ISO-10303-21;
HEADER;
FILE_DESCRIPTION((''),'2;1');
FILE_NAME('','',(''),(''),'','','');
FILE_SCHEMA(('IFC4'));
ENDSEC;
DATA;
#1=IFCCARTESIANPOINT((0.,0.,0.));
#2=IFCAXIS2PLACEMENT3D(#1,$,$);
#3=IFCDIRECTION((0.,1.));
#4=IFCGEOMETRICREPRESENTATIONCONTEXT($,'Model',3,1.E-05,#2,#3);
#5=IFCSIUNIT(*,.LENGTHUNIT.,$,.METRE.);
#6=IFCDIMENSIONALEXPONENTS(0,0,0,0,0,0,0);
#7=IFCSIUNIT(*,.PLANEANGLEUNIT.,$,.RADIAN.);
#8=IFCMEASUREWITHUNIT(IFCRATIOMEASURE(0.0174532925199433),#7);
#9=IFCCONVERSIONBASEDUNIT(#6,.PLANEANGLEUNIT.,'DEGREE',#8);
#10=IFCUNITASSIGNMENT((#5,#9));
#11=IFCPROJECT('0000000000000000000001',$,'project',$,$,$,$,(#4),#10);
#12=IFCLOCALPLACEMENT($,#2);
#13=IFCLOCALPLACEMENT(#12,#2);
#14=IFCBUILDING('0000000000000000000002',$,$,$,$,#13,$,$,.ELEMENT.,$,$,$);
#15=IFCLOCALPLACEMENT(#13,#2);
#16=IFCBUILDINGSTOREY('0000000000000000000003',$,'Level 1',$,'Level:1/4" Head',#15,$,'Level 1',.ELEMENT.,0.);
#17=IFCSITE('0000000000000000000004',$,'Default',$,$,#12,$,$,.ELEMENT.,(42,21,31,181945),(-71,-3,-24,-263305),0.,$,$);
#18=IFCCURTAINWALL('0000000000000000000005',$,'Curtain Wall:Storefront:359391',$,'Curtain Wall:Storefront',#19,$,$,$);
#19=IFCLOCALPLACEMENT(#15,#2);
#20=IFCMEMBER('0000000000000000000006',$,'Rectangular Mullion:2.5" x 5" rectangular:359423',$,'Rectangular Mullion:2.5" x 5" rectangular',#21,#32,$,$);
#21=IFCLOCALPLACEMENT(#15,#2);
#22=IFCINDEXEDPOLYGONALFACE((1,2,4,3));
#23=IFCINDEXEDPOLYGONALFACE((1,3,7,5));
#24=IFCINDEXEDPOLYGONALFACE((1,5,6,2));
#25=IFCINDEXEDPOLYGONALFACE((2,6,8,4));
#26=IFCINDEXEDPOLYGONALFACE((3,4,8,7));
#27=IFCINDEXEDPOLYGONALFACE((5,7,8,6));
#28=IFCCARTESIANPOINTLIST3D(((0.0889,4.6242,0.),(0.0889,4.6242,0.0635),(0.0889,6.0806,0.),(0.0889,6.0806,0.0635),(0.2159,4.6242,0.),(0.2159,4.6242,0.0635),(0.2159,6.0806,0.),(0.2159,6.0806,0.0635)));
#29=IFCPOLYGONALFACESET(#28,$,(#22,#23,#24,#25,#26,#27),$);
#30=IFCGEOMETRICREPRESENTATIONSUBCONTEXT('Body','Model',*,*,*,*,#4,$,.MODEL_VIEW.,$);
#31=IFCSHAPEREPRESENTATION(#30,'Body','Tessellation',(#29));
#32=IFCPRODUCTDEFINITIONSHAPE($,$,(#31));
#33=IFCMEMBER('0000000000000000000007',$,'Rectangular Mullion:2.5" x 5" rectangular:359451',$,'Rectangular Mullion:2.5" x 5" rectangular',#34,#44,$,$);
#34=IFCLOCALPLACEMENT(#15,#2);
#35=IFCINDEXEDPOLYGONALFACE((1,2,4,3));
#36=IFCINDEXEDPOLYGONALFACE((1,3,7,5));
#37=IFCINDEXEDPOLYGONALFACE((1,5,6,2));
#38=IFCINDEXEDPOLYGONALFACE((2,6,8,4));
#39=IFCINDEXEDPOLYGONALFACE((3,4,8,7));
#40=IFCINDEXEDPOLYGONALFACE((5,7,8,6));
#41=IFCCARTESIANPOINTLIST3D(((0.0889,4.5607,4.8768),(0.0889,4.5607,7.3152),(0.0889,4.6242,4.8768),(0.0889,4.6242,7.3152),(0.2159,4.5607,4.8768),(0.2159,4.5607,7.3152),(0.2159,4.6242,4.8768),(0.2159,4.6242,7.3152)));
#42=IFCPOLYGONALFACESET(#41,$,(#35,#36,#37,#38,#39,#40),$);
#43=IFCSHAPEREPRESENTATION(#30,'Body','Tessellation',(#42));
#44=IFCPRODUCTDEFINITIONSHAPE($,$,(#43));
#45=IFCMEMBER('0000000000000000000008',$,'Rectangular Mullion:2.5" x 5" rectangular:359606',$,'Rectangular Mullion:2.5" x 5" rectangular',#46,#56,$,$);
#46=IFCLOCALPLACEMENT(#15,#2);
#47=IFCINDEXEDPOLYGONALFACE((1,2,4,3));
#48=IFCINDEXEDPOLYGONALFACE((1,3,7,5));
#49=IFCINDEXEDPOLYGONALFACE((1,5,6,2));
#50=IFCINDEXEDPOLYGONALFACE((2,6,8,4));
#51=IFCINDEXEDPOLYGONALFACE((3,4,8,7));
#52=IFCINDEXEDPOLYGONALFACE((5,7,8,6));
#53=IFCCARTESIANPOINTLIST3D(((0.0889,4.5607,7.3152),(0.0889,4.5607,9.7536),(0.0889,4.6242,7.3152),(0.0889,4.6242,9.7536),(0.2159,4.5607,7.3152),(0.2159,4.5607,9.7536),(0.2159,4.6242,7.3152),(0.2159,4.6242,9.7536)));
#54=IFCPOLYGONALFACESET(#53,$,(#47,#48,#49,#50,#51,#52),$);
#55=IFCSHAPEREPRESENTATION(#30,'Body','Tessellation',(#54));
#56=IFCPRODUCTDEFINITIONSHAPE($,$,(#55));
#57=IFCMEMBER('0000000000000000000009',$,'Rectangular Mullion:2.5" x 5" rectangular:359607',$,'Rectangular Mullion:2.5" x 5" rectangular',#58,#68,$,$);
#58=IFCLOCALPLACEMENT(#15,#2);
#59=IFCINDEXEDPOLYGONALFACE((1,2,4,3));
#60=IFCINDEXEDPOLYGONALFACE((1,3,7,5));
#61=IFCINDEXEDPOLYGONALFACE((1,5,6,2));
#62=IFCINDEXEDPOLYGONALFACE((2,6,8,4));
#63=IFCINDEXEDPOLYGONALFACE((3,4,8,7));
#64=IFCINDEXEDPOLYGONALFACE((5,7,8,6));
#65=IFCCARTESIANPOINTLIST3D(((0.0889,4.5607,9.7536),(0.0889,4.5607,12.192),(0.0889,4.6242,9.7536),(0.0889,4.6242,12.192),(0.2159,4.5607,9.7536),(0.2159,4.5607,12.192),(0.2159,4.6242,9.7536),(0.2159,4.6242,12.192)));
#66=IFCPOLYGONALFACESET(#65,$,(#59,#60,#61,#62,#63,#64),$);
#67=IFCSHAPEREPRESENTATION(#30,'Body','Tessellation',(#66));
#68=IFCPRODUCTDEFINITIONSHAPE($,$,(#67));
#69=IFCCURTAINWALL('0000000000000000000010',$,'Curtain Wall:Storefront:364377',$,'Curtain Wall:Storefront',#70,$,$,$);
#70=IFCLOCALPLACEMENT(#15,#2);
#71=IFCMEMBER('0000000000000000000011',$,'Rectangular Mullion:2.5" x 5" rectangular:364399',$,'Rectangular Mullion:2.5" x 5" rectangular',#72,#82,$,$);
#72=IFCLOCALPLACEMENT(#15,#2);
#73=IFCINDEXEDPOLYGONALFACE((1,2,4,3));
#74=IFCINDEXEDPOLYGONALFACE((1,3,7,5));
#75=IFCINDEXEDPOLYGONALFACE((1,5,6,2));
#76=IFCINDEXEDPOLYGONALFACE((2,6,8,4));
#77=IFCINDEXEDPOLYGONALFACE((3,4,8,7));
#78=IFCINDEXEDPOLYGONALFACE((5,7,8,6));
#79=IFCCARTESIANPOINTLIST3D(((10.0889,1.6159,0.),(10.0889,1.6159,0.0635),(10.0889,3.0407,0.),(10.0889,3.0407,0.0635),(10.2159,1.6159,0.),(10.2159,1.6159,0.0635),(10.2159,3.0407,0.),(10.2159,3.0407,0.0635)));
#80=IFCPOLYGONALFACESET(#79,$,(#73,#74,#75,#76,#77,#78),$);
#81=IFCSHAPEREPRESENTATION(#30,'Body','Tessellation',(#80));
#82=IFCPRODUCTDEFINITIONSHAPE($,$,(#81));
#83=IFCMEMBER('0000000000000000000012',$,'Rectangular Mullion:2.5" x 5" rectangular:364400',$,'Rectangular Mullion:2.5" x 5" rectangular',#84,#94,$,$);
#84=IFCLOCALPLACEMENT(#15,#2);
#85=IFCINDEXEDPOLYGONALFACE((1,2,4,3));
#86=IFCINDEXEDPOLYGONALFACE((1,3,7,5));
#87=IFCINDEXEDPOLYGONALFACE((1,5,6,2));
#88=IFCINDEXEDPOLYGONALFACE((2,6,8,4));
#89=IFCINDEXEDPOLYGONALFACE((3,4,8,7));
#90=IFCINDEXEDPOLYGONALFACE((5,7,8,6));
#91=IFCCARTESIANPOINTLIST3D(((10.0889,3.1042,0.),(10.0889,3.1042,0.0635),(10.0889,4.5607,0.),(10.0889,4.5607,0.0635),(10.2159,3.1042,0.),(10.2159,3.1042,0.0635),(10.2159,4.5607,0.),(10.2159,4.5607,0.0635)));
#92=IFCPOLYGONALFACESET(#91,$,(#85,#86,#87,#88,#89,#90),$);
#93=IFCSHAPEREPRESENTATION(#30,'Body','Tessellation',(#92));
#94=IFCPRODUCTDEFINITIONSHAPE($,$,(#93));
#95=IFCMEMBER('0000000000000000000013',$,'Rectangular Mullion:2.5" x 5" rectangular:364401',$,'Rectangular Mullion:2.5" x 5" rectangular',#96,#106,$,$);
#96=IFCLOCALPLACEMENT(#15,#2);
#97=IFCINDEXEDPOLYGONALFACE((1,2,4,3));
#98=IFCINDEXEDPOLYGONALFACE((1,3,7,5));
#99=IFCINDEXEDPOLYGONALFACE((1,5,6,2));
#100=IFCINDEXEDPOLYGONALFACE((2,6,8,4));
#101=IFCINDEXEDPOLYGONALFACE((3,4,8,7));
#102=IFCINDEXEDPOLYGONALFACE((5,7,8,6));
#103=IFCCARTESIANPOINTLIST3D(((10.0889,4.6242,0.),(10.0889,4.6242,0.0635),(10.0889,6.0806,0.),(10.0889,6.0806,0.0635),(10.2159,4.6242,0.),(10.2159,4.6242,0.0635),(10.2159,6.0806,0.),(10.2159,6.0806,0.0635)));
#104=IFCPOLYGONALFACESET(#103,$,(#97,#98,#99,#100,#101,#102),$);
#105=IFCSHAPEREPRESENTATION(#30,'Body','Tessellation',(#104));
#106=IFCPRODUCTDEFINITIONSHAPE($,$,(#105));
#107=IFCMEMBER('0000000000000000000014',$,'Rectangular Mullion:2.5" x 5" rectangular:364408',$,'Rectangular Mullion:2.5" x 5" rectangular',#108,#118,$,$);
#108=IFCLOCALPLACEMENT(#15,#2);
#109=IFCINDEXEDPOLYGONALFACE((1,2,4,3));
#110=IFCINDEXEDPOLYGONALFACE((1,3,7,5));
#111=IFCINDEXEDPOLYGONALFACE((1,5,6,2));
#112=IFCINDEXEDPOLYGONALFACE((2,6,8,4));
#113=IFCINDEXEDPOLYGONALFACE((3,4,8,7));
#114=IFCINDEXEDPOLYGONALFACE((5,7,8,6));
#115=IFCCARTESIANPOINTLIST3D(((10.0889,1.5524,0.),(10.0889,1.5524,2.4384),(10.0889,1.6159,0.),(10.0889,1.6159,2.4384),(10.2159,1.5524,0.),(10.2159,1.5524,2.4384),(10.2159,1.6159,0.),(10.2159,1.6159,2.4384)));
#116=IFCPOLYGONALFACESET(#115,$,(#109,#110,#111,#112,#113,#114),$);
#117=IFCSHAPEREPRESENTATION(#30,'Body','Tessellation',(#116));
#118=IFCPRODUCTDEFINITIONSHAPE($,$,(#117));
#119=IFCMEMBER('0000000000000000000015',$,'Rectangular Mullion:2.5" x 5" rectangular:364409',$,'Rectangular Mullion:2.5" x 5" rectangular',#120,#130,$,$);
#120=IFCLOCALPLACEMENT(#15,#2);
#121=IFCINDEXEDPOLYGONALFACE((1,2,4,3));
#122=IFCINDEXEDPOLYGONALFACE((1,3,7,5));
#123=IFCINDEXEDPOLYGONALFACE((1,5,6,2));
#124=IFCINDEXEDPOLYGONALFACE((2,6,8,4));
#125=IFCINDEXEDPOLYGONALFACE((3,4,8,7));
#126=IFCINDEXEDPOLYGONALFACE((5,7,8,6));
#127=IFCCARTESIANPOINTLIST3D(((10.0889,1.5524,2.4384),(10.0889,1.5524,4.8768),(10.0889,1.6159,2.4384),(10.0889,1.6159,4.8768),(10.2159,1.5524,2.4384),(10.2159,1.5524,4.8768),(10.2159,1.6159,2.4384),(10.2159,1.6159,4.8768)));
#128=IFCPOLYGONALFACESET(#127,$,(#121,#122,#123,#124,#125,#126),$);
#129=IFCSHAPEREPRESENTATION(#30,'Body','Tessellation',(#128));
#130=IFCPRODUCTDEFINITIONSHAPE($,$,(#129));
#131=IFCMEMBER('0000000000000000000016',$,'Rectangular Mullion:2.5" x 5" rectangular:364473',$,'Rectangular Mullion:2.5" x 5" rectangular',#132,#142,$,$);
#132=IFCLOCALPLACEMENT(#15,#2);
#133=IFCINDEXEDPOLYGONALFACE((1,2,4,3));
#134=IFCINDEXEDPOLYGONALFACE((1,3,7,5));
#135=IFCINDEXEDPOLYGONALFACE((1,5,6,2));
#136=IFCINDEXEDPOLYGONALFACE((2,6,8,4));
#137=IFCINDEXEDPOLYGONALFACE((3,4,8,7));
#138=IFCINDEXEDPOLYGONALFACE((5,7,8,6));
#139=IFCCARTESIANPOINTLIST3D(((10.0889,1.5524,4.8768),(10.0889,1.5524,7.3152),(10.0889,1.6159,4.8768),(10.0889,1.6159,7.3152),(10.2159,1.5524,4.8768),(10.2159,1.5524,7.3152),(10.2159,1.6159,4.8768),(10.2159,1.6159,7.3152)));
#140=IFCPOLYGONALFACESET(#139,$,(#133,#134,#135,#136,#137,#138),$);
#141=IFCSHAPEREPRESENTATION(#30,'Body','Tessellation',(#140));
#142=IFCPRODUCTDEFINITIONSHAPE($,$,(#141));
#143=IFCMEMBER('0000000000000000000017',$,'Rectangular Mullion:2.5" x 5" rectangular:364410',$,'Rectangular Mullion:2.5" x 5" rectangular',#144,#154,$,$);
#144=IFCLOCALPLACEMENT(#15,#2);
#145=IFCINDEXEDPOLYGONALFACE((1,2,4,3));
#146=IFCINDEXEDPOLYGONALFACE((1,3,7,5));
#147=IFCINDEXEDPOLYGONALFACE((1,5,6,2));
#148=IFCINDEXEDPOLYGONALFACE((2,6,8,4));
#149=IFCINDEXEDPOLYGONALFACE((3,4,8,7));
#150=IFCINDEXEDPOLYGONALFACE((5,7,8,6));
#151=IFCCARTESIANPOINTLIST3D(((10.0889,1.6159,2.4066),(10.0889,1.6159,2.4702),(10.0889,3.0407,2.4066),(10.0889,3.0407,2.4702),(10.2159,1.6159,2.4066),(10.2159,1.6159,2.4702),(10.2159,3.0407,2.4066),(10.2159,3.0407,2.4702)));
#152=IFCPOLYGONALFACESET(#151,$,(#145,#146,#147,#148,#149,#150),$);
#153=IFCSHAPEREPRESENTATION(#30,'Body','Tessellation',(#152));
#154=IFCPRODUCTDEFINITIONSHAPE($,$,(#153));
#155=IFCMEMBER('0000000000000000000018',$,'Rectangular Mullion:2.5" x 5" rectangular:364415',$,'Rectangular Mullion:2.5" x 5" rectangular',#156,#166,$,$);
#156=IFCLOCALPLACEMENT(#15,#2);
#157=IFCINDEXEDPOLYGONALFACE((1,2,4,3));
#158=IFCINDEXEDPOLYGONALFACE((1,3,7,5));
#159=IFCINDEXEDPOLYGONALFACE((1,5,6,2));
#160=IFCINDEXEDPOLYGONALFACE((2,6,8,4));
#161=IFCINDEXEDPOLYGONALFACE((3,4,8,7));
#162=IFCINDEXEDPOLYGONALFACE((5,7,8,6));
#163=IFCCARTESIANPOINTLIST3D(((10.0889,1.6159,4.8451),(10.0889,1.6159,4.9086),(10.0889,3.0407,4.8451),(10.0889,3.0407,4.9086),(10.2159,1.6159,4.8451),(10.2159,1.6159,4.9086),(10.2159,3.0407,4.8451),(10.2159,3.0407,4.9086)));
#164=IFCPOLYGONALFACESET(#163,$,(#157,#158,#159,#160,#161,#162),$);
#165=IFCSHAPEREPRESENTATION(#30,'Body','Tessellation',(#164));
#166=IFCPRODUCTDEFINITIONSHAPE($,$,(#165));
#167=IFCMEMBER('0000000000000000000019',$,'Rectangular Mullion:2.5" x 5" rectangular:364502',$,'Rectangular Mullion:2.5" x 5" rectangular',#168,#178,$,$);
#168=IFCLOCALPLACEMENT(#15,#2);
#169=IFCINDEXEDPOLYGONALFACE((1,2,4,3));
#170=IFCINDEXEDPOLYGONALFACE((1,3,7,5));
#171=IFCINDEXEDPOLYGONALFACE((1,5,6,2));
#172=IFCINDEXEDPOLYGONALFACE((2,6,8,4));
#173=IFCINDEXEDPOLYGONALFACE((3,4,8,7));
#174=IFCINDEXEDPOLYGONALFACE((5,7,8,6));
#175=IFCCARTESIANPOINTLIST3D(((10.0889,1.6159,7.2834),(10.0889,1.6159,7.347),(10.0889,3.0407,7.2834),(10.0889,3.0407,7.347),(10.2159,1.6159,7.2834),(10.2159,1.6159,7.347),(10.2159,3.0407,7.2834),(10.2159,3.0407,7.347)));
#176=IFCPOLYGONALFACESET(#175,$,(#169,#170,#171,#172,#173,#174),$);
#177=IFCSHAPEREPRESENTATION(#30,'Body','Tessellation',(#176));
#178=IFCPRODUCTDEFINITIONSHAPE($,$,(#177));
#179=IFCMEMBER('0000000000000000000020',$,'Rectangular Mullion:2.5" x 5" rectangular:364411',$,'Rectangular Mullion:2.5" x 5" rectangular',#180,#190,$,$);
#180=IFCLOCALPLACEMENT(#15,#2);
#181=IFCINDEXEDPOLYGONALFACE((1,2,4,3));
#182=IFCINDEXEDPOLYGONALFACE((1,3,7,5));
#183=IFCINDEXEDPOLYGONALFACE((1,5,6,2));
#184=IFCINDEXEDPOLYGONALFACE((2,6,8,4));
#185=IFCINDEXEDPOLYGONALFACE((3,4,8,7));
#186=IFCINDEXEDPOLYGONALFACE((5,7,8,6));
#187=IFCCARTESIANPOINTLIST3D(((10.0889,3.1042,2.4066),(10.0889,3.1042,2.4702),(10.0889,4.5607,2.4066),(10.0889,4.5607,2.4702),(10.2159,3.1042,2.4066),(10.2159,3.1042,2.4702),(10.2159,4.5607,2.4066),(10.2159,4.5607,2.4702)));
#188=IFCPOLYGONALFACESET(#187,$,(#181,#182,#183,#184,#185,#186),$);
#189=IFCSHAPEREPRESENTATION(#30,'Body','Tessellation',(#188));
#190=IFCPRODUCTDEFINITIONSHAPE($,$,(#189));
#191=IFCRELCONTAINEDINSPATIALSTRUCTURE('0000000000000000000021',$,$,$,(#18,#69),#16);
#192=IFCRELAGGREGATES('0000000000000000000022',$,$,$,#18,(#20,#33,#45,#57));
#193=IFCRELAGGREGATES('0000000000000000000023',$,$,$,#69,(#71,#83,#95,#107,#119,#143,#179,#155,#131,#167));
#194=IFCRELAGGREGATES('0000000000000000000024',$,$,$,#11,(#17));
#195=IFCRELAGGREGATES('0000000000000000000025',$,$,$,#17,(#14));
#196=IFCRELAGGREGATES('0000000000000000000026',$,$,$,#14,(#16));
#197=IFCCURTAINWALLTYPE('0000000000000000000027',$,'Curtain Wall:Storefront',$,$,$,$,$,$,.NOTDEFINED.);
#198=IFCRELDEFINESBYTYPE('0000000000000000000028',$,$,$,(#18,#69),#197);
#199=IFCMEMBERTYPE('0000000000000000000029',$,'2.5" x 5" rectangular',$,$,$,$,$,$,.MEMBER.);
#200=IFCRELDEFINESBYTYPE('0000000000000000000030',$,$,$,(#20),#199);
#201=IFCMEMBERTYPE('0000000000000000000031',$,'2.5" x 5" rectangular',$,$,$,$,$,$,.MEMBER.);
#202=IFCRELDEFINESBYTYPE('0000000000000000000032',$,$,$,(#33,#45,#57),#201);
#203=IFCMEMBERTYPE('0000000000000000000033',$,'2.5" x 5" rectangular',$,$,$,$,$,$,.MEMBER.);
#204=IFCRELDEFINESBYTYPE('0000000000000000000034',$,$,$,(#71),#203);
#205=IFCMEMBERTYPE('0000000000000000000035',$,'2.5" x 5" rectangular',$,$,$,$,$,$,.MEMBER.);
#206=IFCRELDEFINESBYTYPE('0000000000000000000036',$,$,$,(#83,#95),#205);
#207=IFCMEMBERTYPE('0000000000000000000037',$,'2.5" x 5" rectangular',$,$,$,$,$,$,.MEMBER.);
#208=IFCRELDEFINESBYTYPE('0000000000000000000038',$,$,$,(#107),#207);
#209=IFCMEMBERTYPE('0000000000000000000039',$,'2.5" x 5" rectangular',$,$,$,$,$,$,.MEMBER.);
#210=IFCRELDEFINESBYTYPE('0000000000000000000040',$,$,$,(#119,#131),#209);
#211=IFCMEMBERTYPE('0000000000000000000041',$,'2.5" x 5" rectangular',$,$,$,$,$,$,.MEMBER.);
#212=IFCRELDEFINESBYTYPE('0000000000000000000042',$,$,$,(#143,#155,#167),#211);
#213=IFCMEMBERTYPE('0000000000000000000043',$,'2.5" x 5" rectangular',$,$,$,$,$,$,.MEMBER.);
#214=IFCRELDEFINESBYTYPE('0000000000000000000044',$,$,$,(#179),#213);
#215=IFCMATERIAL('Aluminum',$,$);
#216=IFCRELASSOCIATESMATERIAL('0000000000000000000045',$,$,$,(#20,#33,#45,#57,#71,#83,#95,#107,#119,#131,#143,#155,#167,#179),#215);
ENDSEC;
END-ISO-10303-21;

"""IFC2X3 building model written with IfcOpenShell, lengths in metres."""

from ifc_helpers import new_model, entity, si_unit, converted_unit, direction, frame, origin, origin_2d_with_axis, place, context, subcontext, project, spatial, rectangle, extrude, source, transform, mapped, material, type_object, type_shapes, element, aggregate, save


model = new_model("IFC2X3")

# Units and contexts
model_context = context("Model", 3, precision=1e-05, world=origin(), true_north=direction((0.0, 1.0)))
body_context = subcontext(model_context, "Body", "Model", "MODEL_VIEW")
ifc_project = project(units=[si_unit("LENGTHUNIT", "METRE"), converted_unit("PLANEANGLEUNIT", "DEGREE", entity("IfcRatioMeasure", 0.0174532925199433), si_unit("PLANEANGLEUNIT", "RADIAN"), dimensions=[0, 0, 0, 0, 0, 0, 0])], contexts=[model_context])

# Site, building, storey
site_placement = place(None, origin())
site = spatial("IfcSite", under=ifc_project, at=site_placement, Name="Default", CompositionType="ELEMENT", RefLatitude=(42, 21, 31, 181945), RefLongitude=(-71, -3, -24, -263305), RefElevation=0.0)
building_placement = place(site_placement, origin())
building = spatial("IfcBuilding", under=site, at=building_placement, CompositionType="ELEMENT")
storey_placement = place(building_placement, origin())
storey = spatial("IfcBuildingStorey", under=building, at=storey_placement, Name="Level 1", ObjectType="Level:1/4\" Head", LongName="Level 1", CompositionType="ELEMENT", Elevation=0.0)

# Curtain wall, members
curtain_wall_type = type_object("IfcCurtainWallType", Name="Curtain Wall:Storefront", PredefinedType="NOTDEFINED")
curtain_wall_1_placement = place(storey_placement, origin())
curtain_wall_1 = element("IfcCurtainWall", 1, at=curtain_wall_1_placement, inside=storey, type_object=curtain_wall_type, Name="Curtain Wall:Storefront:359391", ObjectType="Curtain Wall:Storefront")
ifc_material_1 = material(Name="Aluminum")
member_type_1 = type_object("IfcMemberType", Name="2.5\" x 5\" rectangular", PredefinedType="MEMBER")
shared_shape_1 = source(origin(), body_context, "Body", "SweptSolid", [
    extrude(rectangle(XDim=0.127, YDim=0.0635, at=origin_2d_with_axis()), frame((-0.0318, 0.0, -1.4565), z_axis=(0.0, 0.0, 1.0), x_axis=(0.0, -1.0, 0.0)), (0.0, 0.0, 1.0), 1.4565),
])
type_shapes(member_type_1, [shared_shape_1])
member_1_placement = place(storey_placement, frame((0.1524, 4.6242, 0.0), z_axis=(0.0, -1.0, 0.0), x_axis=(0.0, 0.0, -1.0)))
member_1 = element("IfcMember", 2, at=member_1_placement, type_object=member_type_1, material=ifc_material_1, Name="Rectangular Mullion:2.5\" x 5\" rectangular:359423", ObjectType="Rectangular Mullion:2.5\" x 5\" rectangular", context=body_context, shape_type="MappedRepresentation", body=[
    mapped(shared_shape_1, transform((0.0, 0.0, 0.0), scale=1.0)),
])
member_type_2 = type_object("IfcMemberType", Name="2.5\" x 5\" rectangular", PredefinedType="MEMBER")
shared_shape_2 = source(origin(), body_context, "Body", "SweptSolid", [
    extrude(rectangle(XDim=0.127, YDim=0.0635, at=origin_2d_with_axis()), frame((0.0, 0.0, -2.4384), z_axis=(0.0, 0.0, 1.0), x_axis=(0.0, -1.0, 0.0)), (0.0, 0.0, 1.0), 2.4384),
])
type_shapes(member_type_2, [shared_shape_2])
member_2_placement = place(storey_placement, frame((0.1524, 4.5924, 4.8768), z_axis=(0.0, 0.0, -1.0), x_axis=(0.0, 1.0, 0.0)))
member_2 = element("IfcMember", 3, at=member_2_placement, type_object=member_type_2, material=ifc_material_1, Name="Rectangular Mullion:2.5\" x 5\" rectangular:359451", ObjectType="Rectangular Mullion:2.5\" x 5\" rectangular", context=body_context, shape_type="MappedRepresentation", body=[
    mapped(shared_shape_2, transform((0.0, 0.0, 0.0), scale=1.0)),
])
member_3_placement = place(storey_placement, frame((0.1524, 4.5924, 7.3152), z_axis=(0.0, 0.0, -1.0), x_axis=(0.0, 1.0, 0.0)))
member_3 = element("IfcMember", 4, at=member_3_placement, type_object=member_type_2, material=ifc_material_1, Name="Rectangular Mullion:2.5\" x 5\" rectangular:359606", ObjectType="Rectangular Mullion:2.5\" x 5\" rectangular", context=body_context, shape_type="MappedRepresentation", body=[
    mapped(shared_shape_2, transform((0.0, 0.0, 0.0), scale=1.0)),
])
member_4_placement = place(storey_placement, frame((0.1524, 4.5924, 9.7536), z_axis=(0.0, 0.0, -1.0), x_axis=(0.0, 1.0, 0.0)))
member_4 = element("IfcMember", 5, at=member_4_placement, type_object=member_type_2, material=ifc_material_1, Name="Rectangular Mullion:2.5\" x 5\" rectangular:359607", ObjectType="Rectangular Mullion:2.5\" x 5\" rectangular", context=body_context, shape_type="MappedRepresentation", body=[
    mapped(shared_shape_2, transform((0.0, 0.0, 0.0), scale=1.0)),
])
aggregate(curtain_wall_1, [member_1, member_2, member_3, member_4])

# Curtain wall, members
curtain_wall_2_placement = place(storey_placement, origin())
curtain_wall_2 = element("IfcCurtainWall", 6, at=curtain_wall_2_placement, inside=storey, type_object=curtain_wall_type, Name="Curtain Wall:Storefront:364377", ObjectType="Curtain Wall:Storefront")
member_type_3 = type_object("IfcMemberType", Name="2.5\" x 5\" rectangular", PredefinedType="MEMBER")
shared_shape_3 = source(origin(), body_context, "Body", "SweptSolid", [
    extrude(rectangle(XDim=0.127, YDim=0.0635, at=origin_2d_with_axis()), frame((-0.0318, 0.0, -1.4248), z_axis=(0.0, 0.0, 1.0), x_axis=(0.0, -1.0, 0.0)), (0.0, 0.0, 1.0), 1.4248),
])
type_shapes(member_type_3, [shared_shape_3])
member_5_placement = place(storey_placement, frame((10.1524, 1.6159, 0.0), z_axis=(0.0, -1.0, 0.0), x_axis=(0.0, 0.0, -1.0)))
member_5 = element("IfcMember", 7, at=member_5_placement, type_object=member_type_3, material=ifc_material_1, Name="Rectangular Mullion:2.5\" x 5\" rectangular:364399", ObjectType="Rectangular Mullion:2.5\" x 5\" rectangular", context=body_context, shape_type="MappedRepresentation", body=[
    mapped(shared_shape_3, transform((0.0, 0.0, 0.0), scale=1.0)),
])
member_type_4 = type_object("IfcMemberType", Name="2.5\" x 5\" rectangular", PredefinedType="MEMBER")
shared_shape_4 = source(origin(), body_context, "Body", "SweptSolid", [
    extrude(rectangle(XDim=0.127, YDim=0.0635, at=origin_2d_with_axis()), frame((-0.0318, 0.0, -1.4565), z_axis=(0.0, 0.0, 1.0), x_axis=(0.0, -1.0, 0.0)), (0.0, 0.0, 1.0), 1.4565),
])
type_shapes(member_type_4, [shared_shape_4])
member_6_placement = place(storey_placement, frame((10.1524, 3.1042, 0.0), z_axis=(0.0, -1.0, 0.0), x_axis=(0.0, 0.0, -1.0)))
member_6 = element("IfcMember", 8, at=member_6_placement, type_object=member_type_4, material=ifc_material_1, Name="Rectangular Mullion:2.5\" x 5\" rectangular:364400", ObjectType="Rectangular Mullion:2.5\" x 5\" rectangular", context=body_context, shape_type="MappedRepresentation", body=[
    mapped(shared_shape_4, transform((0.0, 0.0, 0.0), scale=1.0)),
])
member_7_placement = place(storey_placement, frame((10.1524, 4.6242, 0.0), z_axis=(0.0, -1.0, 0.0), x_axis=(0.0, 0.0, -1.0)))
member_7 = element("IfcMember", 9, at=member_7_placement, type_object=member_type_4, material=ifc_material_1, Name="Rectangular Mullion:2.5\" x 5\" rectangular:364401", ObjectType="Rectangular Mullion:2.5\" x 5\" rectangular", context=body_context, shape_type="MappedRepresentation", body=[
    mapped(shared_shape_4, transform((0.0, 0.0, 0.0), scale=1.0)),
])
member_type_5 = type_object("IfcMemberType", Name="2.5\" x 5\" rectangular", PredefinedType="MEMBER")
shared_shape_5 = source(origin(), body_context, "Body", "SweptSolid", [
    extrude(rectangle(XDim=0.127, YDim=0.0635, at=origin_2d_with_axis()), frame((-0.0318, 0.0, -2.4384), z_axis=(0.0, 0.0, 1.0), x_axis=(0.0, -1.0, 0.0)), (0.0, 0.0, 1.0), 2.4384),
])
type_shapes(member_type_5, [shared_shape_5])
member_8_placement = place(storey_placement, frame((10.1524, 1.5524, 2.4384), z_axis=(0.0, 0.0, 1.0), x_axis=(0.0, -1.0, 0.0)))
member_8 = element("IfcMember", 10, at=member_8_placement, type_object=member_type_5, material=ifc_material_1, Name="Rectangular Mullion:2.5\" x 5\" rectangular:364408", ObjectType="Rectangular Mullion:2.5\" x 5\" rectangular", context=body_context, shape_type="MappedRepresentation", body=[
    mapped(shared_shape_5, transform((0.0, 0.0, 0.0), scale=1.0)),
])
member_type_6 = type_object("IfcMemberType", Name="2.5\" x 5\" rectangular", PredefinedType="MEMBER")
shared_shape_6 = source(origin(), body_context, "Body", "SweptSolid", [
    extrude(rectangle(XDim=0.127, YDim=0.0635, at=origin_2d_with_axis()), frame((-0.0318, 0.0, -2.4384), z_axis=(0.0, 0.0, 1.0), x_axis=(0.0, -1.0, 0.0)), (0.0, 0.0, 1.0), 2.4384),
])
type_shapes(member_type_6, [shared_shape_6])
member_9_placement = place(storey_placement, frame((10.1524, 1.5524, 4.8768), z_axis=(0.0, 0.0, 1.0), x_axis=(0.0, -1.0, 0.0)))
member_9 = element("IfcMember", 11, at=member_9_placement, type_object=member_type_6, material=ifc_material_1, Name="Rectangular Mullion:2.5\" x 5\" rectangular:364409", ObjectType="Rectangular Mullion:2.5\" x 5\" rectangular", context=body_context, shape_type="MappedRepresentation", body=[
    mapped(shared_shape_6, transform((0.0, 0.0, 0.0), scale=1.0)),
])
member_10_placement = place(storey_placement, frame((10.1524, 1.5524, 7.3152), z_axis=(0.0, 0.0, 1.0), x_axis=(0.0, -1.0, 0.0)))
member_10 = element("IfcMember", 12, at=member_10_placement, type_object=member_type_6, material=ifc_material_1, Name="Rectangular Mullion:2.5\" x 5\" rectangular:364473", ObjectType="Rectangular Mullion:2.5\" x 5\" rectangular", context=body_context, shape_type="MappedRepresentation", body=[
    mapped(shared_shape_6, transform((0.0, 0.0, 0.0), scale=1.0)),
])
member_type_7 = type_object("IfcMemberType", Name="2.5\" x 5\" rectangular", PredefinedType="MEMBER")
shared_shape_7 = source(origin(), body_context, "Body", "SweptSolid", [
    extrude(rectangle(XDim=0.127, YDim=0.0635, at=origin_2d_with_axis()), frame((0.0, 0.0, -1.4248), z_axis=(0.0, 0.0, 1.0), x_axis=(0.0, -1.0, 0.0)), (0.0, 0.0, 1.0), 1.4248),
])
type_shapes(member_type_7, [shared_shape_7])
member_11_placement = place(storey_placement, frame((10.1524, 3.0407, 2.4384), z_axis=(0.0, 1.0, 0.0), x_axis=(0.0, 0.0, 1.0)))
member_11 = element("IfcMember", 13, at=member_11_placement, type_object=member_type_7, material=ifc_material_1, Name="Rectangular Mullion:2.5\" x 5\" rectangular:364410", ObjectType="Rectangular Mullion:2.5\" x 5\" rectangular", context=body_context, shape_type="MappedRepresentation", body=[
    mapped(shared_shape_7, transform((0.0, 0.0, 0.0), scale=1.0)),
])
member_12_placement = place(storey_placement, frame((10.1524, 3.0407, 4.8768), z_axis=(0.0, 1.0, 0.0), x_axis=(0.0, 0.0, 1.0)))
member_12 = element("IfcMember", 14, at=member_12_placement, type_object=member_type_7, material=ifc_material_1, Name="Rectangular Mullion:2.5\" x 5\" rectangular:364415", ObjectType="Rectangular Mullion:2.5\" x 5\" rectangular", context=body_context, shape_type="MappedRepresentation", body=[
    mapped(shared_shape_7, transform((0.0, 0.0, 0.0), scale=1.0)),
])
member_13_placement = place(storey_placement, frame((10.1524, 3.0407, 7.3152), z_axis=(0.0, 1.0, 0.0), x_axis=(0.0, 0.0, 1.0)))
member_13 = element("IfcMember", 15, at=member_13_placement, type_object=member_type_7, material=ifc_material_1, Name="Rectangular Mullion:2.5\" x 5\" rectangular:364502", ObjectType="Rectangular Mullion:2.5\" x 5\" rectangular", context=body_context, shape_type="MappedRepresentation", body=[
    mapped(shared_shape_7, transform((0.0, 0.0, 0.0), scale=1.0)),
])
member_type_8 = type_object("IfcMemberType", Name="2.5\" x 5\" rectangular", PredefinedType="MEMBER")
shared_shape_8 = source(origin(), body_context, "Body", "SweptSolid", [
    extrude(rectangle(XDim=0.127, YDim=0.0635, at=origin_2d_with_axis()), frame((0.0, 0.0, -1.4565), z_axis=(0.0, 0.0, 1.0), x_axis=(0.0, -1.0, 0.0)), (0.0, 0.0, 1.0), 1.4565),
])
type_shapes(member_type_8, [shared_shape_8])
member_14_placement = place(storey_placement, frame((10.1524, 4.5607, 2.4384), z_axis=(0.0, 1.0, 0.0), x_axis=(0.0, 0.0, 1.0)))
member_14 = element("IfcMember", 16, at=member_14_placement, type_object=member_type_8, material=ifc_material_1, Name="Rectangular Mullion:2.5\" x 5\" rectangular:364411", ObjectType="Rectangular Mullion:2.5\" x 5\" rectangular", context=body_context, shape_type="MappedRepresentation", body=[
    mapped(shared_shape_8, transform((0.0, 0.0, 0.0), scale=1.0)),
])
aggregate(curtain_wall_2, [member_5, member_6, member_7, member_8, member_9, member_11, member_14, member_12, member_10, member_13])

save(model, "model.ifc")
